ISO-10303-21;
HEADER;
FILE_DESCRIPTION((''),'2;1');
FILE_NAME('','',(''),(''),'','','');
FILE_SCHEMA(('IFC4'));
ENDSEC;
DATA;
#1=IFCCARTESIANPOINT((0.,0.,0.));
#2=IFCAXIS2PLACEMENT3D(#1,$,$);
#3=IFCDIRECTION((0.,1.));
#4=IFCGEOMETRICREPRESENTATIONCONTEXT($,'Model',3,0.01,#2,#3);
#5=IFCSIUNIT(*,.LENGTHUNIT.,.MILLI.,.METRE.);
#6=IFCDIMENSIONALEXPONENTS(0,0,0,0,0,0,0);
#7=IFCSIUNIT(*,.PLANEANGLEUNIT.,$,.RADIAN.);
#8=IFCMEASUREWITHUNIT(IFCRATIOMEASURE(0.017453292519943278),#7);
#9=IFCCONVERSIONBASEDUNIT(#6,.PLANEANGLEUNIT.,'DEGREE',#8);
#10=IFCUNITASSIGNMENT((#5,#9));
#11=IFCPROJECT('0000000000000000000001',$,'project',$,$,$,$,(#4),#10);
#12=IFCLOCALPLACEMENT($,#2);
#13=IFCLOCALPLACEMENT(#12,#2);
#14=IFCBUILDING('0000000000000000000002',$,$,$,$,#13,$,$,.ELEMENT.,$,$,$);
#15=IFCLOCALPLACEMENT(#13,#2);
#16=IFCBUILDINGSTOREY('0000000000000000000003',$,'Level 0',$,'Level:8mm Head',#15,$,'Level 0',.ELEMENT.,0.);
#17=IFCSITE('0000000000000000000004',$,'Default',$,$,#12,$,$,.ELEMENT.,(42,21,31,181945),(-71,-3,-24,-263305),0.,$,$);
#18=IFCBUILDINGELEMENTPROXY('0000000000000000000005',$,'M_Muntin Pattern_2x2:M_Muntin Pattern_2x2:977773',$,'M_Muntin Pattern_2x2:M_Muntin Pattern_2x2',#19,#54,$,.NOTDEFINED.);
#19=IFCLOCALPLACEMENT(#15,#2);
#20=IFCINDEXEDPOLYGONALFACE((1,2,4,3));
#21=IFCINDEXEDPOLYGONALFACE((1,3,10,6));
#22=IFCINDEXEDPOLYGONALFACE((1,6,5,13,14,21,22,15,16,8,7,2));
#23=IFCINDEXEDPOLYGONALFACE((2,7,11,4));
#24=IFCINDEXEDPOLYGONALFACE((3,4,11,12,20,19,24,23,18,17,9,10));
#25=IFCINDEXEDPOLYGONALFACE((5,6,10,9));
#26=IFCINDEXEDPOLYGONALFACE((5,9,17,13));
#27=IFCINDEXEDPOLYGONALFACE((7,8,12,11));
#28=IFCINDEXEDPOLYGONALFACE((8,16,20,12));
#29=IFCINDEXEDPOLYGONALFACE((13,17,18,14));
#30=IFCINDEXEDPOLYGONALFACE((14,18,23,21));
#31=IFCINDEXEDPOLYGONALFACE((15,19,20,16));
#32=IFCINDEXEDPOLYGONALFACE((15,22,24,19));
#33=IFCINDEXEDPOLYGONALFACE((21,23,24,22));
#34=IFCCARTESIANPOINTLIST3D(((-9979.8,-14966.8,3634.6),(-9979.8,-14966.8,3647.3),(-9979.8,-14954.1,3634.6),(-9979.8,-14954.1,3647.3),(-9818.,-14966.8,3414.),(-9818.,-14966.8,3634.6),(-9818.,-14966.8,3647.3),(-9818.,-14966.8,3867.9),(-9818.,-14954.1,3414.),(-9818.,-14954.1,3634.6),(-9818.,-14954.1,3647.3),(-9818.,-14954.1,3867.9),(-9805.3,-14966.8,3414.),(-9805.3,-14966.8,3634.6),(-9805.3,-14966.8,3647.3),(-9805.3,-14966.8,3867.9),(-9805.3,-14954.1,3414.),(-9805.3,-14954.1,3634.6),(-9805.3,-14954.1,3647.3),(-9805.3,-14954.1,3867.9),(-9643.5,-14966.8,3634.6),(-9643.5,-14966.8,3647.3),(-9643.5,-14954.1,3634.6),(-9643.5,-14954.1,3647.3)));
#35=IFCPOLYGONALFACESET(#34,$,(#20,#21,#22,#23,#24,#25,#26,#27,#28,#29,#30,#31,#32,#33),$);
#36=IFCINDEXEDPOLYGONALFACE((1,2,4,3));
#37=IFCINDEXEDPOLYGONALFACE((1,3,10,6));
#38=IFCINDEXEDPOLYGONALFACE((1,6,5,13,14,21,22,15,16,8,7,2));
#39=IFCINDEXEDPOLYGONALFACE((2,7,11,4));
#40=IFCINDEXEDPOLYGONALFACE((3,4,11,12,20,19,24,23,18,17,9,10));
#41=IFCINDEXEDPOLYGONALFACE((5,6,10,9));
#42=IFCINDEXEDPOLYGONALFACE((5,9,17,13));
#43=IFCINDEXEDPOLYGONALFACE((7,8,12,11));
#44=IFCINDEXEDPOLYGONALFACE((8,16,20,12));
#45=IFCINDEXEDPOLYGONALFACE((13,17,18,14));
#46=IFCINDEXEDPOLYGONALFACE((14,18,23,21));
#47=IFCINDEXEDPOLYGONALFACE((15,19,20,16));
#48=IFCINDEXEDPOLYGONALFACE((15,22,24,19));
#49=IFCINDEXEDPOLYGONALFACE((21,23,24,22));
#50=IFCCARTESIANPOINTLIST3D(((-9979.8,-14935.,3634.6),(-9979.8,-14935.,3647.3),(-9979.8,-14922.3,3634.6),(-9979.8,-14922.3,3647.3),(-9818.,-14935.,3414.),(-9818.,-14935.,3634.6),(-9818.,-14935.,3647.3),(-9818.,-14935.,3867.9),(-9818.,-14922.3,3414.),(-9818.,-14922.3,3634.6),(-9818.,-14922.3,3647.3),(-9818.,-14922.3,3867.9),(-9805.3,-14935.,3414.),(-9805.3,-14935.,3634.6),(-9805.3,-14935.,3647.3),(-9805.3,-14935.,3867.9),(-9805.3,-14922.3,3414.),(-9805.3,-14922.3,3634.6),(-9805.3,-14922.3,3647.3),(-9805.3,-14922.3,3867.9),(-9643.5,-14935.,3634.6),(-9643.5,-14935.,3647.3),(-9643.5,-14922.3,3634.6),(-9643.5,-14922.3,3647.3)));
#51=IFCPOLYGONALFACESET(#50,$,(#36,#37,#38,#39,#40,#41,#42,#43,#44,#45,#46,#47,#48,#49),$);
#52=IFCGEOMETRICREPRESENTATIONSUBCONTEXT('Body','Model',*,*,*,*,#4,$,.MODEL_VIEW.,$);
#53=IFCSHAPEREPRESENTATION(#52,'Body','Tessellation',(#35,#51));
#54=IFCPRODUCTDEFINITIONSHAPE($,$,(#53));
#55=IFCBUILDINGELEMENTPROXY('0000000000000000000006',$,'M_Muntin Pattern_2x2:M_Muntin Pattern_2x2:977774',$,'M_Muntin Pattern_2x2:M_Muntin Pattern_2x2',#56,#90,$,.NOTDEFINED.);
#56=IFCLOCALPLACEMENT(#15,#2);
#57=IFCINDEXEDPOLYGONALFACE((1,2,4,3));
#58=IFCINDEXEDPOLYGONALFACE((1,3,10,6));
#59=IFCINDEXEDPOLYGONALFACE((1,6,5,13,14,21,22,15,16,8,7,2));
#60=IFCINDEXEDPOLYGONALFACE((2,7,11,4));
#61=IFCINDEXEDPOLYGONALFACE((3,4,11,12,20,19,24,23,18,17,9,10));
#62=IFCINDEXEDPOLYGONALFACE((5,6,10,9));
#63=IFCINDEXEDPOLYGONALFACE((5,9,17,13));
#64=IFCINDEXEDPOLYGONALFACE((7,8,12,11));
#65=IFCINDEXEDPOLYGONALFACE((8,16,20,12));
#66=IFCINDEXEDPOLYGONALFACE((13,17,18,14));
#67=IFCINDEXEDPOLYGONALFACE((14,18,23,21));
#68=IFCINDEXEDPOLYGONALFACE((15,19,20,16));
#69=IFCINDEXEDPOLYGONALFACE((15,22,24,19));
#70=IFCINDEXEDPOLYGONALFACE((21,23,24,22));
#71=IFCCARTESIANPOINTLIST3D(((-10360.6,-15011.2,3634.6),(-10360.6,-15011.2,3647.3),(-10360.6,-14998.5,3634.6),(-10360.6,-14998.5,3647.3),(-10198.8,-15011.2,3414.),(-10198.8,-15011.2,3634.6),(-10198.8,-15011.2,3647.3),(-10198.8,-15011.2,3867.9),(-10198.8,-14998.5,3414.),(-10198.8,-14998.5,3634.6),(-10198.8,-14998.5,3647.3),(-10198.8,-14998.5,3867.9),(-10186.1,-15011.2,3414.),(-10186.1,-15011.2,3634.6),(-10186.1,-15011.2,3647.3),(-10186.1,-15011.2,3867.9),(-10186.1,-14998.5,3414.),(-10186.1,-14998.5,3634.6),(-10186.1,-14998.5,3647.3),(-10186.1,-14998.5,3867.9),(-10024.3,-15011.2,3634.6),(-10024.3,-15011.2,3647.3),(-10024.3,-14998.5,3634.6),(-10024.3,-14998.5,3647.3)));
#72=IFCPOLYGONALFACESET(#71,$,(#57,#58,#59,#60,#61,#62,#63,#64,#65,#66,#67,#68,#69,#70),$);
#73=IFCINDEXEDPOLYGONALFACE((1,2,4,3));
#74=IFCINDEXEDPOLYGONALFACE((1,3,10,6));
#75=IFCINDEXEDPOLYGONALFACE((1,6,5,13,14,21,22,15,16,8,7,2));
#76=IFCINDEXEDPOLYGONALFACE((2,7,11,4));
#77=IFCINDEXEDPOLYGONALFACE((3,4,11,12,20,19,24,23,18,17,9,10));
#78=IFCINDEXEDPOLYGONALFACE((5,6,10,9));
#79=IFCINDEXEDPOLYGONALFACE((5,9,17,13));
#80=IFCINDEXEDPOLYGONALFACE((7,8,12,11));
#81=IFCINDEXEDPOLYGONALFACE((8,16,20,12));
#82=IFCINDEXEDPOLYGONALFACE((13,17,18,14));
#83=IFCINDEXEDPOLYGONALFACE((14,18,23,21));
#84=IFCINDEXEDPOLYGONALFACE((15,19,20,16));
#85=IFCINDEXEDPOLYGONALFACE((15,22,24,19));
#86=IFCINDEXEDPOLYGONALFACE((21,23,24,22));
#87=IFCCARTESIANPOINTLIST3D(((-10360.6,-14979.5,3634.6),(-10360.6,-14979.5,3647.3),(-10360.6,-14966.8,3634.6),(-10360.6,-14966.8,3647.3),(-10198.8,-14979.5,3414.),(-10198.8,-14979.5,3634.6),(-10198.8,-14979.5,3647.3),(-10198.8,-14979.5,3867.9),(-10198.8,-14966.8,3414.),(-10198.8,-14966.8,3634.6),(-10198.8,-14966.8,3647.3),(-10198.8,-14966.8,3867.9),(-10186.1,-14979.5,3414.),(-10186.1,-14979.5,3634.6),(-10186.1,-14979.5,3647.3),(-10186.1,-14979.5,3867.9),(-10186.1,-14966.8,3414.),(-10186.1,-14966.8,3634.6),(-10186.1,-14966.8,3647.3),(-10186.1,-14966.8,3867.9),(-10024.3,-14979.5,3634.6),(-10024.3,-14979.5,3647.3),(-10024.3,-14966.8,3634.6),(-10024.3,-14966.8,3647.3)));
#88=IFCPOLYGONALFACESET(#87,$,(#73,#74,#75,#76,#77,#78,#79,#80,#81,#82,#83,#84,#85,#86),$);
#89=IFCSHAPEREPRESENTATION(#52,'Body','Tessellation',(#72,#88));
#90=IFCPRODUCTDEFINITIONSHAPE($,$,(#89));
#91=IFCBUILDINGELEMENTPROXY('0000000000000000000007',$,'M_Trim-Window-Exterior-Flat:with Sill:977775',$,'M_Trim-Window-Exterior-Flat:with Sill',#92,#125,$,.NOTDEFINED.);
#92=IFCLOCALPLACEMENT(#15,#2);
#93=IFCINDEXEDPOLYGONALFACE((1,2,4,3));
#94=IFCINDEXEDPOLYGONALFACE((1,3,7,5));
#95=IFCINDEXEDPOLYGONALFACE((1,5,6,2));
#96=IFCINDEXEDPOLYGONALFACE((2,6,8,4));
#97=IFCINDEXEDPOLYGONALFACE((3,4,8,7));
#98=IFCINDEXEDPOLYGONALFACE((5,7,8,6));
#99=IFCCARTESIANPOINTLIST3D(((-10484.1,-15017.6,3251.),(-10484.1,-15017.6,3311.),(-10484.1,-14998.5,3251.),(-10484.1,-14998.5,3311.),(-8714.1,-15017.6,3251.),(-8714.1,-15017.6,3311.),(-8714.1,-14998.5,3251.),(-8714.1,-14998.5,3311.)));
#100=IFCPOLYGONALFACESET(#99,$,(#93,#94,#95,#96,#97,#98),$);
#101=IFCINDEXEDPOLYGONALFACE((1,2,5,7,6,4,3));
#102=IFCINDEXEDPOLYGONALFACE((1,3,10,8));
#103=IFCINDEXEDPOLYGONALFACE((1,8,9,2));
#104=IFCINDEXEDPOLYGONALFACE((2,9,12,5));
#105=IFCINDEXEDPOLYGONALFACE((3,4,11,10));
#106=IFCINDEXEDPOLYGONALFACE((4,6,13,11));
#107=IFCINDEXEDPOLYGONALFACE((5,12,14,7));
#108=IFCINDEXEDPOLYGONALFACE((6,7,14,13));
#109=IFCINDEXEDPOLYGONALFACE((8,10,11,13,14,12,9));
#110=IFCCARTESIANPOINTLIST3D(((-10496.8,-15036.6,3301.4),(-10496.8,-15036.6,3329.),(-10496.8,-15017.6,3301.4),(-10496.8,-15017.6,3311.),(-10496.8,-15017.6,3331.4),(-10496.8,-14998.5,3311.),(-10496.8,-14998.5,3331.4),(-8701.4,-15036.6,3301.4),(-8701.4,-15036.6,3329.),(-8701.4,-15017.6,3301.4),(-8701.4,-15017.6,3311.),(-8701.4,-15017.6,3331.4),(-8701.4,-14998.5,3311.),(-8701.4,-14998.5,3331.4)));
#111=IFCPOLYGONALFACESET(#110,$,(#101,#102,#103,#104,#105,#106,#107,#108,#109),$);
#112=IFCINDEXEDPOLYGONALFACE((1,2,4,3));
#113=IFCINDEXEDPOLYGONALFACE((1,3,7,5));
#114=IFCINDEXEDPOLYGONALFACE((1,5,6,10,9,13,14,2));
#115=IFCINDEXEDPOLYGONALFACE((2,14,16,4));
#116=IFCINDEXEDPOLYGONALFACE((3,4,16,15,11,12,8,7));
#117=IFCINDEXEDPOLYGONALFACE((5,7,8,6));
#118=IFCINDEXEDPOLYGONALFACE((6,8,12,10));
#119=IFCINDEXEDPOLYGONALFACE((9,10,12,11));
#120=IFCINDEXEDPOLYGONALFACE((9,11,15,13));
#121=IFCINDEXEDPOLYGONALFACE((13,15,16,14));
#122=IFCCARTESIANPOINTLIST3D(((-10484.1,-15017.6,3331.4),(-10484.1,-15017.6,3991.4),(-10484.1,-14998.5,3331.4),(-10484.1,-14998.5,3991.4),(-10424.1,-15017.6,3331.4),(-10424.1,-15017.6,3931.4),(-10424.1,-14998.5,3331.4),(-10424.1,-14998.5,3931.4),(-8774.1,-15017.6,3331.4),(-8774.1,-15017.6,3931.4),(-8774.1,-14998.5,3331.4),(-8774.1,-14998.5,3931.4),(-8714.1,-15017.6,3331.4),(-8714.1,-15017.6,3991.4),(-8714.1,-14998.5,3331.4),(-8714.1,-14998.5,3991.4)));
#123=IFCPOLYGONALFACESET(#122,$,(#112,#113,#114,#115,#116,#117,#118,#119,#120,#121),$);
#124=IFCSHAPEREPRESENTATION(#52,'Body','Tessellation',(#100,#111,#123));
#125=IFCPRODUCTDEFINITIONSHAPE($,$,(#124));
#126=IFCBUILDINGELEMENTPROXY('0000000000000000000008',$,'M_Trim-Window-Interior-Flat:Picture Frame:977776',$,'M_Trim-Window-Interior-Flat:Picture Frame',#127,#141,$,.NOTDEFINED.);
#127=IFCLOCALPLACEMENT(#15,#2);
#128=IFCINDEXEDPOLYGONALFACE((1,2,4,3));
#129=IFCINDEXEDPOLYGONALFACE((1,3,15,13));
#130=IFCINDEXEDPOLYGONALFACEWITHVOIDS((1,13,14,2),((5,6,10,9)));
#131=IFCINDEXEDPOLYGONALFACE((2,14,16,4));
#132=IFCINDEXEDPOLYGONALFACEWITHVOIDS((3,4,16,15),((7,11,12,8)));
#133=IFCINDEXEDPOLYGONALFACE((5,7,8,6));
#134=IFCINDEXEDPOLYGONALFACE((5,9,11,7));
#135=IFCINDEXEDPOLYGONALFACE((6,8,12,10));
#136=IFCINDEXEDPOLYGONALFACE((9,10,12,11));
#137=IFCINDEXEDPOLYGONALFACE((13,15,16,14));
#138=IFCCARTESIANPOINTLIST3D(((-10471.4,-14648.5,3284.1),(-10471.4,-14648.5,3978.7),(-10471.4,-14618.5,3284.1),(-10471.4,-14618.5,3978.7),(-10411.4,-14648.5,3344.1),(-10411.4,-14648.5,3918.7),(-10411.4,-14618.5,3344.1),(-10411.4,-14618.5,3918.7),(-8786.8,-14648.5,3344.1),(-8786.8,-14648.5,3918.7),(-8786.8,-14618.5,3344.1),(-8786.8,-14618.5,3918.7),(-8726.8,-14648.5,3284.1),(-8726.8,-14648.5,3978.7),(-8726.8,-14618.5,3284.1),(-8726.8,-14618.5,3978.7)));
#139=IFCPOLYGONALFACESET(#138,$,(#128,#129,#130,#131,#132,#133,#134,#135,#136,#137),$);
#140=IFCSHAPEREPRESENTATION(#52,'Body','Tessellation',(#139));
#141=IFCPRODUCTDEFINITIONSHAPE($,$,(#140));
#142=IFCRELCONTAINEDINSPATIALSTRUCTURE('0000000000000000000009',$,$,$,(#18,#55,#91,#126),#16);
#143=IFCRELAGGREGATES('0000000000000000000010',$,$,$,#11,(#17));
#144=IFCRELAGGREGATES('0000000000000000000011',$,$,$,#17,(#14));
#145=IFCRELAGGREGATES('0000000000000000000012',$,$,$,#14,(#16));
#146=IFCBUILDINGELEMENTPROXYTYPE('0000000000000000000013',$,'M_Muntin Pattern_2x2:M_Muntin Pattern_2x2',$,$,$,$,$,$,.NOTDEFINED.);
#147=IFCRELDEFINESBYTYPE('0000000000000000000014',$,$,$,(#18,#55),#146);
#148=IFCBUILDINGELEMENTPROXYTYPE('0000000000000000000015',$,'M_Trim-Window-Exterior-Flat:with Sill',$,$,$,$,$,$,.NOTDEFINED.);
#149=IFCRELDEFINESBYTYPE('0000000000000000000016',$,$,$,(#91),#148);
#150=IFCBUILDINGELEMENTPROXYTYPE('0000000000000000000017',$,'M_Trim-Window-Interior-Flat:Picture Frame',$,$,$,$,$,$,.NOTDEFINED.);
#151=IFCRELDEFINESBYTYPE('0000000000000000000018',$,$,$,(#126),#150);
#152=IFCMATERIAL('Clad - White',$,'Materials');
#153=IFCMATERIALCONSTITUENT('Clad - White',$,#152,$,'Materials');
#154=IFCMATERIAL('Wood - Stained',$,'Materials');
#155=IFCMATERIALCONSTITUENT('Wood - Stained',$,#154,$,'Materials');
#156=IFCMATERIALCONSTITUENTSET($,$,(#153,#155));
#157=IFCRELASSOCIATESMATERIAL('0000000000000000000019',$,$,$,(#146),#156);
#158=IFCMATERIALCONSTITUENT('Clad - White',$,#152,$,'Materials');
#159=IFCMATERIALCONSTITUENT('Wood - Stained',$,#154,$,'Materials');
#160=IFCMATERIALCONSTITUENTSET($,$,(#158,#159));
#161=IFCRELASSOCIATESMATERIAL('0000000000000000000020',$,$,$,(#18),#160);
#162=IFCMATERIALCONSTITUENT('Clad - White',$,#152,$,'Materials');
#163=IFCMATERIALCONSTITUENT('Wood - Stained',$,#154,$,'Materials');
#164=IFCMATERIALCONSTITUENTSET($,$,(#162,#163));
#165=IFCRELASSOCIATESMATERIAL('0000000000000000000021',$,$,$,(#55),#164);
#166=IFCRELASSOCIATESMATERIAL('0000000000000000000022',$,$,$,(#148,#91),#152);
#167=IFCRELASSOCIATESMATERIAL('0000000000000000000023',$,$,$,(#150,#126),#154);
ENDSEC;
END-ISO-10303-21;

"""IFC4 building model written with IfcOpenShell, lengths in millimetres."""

from ifc_helpers import new_model, entity, si_unit, converted_unit, direction, frame, frame_2d, origin, place, context, subcontext, project, spatial, polyline, rectangle, outline, extrude, source, transform, mapped, material, constituent, constituent_set, type_object, type_shapes, element, save


model = new_model("IFC4")

# Units and contexts
model_context = context("Model", 3, precision=0.01, world=origin(), true_north=direction((0.0, 1.0)))
body_context = subcontext(model_context, "Body", "Model", "MODEL_VIEW")
ifc_project = project(units=[si_unit("LENGTHUNIT", "METRE", prefix="MILLI"), converted_unit("PLANEANGLEUNIT", "DEGREE", entity("IfcRatioMeasure", 0.017453292519943278), si_unit("PLANEANGLEUNIT", "RADIAN"), dimensions=[0, 0, 0, 0, 0, 0, 0])], contexts=[model_context])

# Site, building, storey
site_placement = place(None, origin())
site = spatial("IfcSite", under=ifc_project, at=site_placement, Name="Default", CompositionType="ELEMENT", RefLatitude=(42, 21, 31, 181945), RefLongitude=(-71, -3, -24, -263305), RefElevation=0.0)
building_placement = place(site_placement, origin())
building = spatial("IfcBuilding", under=site, at=building_placement, CompositionType="ELEMENT")
storey_placement = place(building_placement, origin())
storey = spatial("IfcBuildingStorey", under=building, at=storey_placement, Name="Level 0", ObjectType="Level:8mm Head", LongName="Level 0", CompositionType="ELEMENT", Elevation=0.0)

# Building element proxies
ifc_material_1 = material(Name="Clad - White", Category="Materials")
ifc_material_2 = material(Name="Wood - Stained", Category="Materials")
ifc_constituent_1 = constituent(ifc_material_1, Name="Clad - White", Category="Materials")
ifc_constituent_2 = constituent(ifc_material_2, Name="Wood - Stained", Category="Materials")
ifc_constituent_set_1 = constituent_set(constituents=[ifc_constituent_1, ifc_constituent_2])
building_element_proxy_type_1 = type_object("IfcBuildingElementProxyType", Name="M_Muntin Pattern_2x2:M_Muntin Pattern_2x2", PredefinedType="NOTDEFINED", material=ifc_constituent_set_1)
shared_shape_1 = source(origin(), body_context, "Body", "SweptSolid", [
    extrude(outline(polyline([(6.4, -6.4), (227.0, -6.4), (227.0, 6.3), (6.4, 6.3), (6.4, 168.2), (-6.3, 168.2), (-6.3, 6.3), (-227.0, 6.3), (-227.0, -6.4), (-6.3, -6.4), (-6.3, -168.1), (6.4, -168.1), (6.4, -6.4)])), frame((0.0, 9.5, 227.0), z_axis=(0.0, 1.0, 0.0), x_axis=(0.0, 0.0, 1.0)), (0.0, 0.0, 1.0), 12.7),
    extrude(outline(polyline([(6.4, -6.4), (227.0, -6.4), (227.0, 6.3), (6.4, 6.3), (6.4, 168.2), (-6.3, 168.2), (-6.3, 6.3), (-227.0, 6.3), (-227.0, -6.4), (-6.3, -6.4), (-6.3, -168.1), (6.4, -168.1), (6.4, -6.4)])), frame((0.0, -22.2, 227.0), z_axis=(0.0, 1.0, 0.0), x_axis=(0.0, 0.0, 1.0)), (0.0, 0.0, 1.0), 12.7),
])
type_shapes(building_element_proxy_type_1, [shared_shape_1])
ifc_constituent_3 = constituent(ifc_material_1, Name="Clad - White", Category="Materials")
ifc_constituent_4 = constituent(ifc_material_2, Name="Wood - Stained", Category="Materials")
ifc_constituent_set_2 = constituent_set(constituents=[ifc_constituent_3, ifc_constituent_4])
proxy_1_placement = place(storey_placement, frame((-9811.7, -14944.6, 3414.0), z_axis=(0.0, 0.0, 1.0), x_axis=(-1.0, 0.0, 0.0)))
element("IfcBuildingElementProxy", 1, at=proxy_1_placement, inside=storey, type_object=building_element_proxy_type_1, material=ifc_constituent_set_2, Name="M_Muntin Pattern_2x2:M_Muntin Pattern_2x2:977773", ObjectType="M_Muntin Pattern_2x2:M_Muntin Pattern_2x2", PredefinedType="NOTDEFINED", context=body_context, shape_type="MappedRepresentation", body=[
    mapped(shared_shape_1, transform((0.0, 0.0, 0.0), scale=1.0)),
])
ifc_constituent_5 = constituent(ifc_material_1, Name="Clad - White", Category="Materials")
ifc_constituent_6 = constituent(ifc_material_2, Name="Wood - Stained", Category="Materials")
ifc_constituent_set_3 = constituent_set(constituents=[ifc_constituent_5, ifc_constituent_6])
proxy_2_placement = place(storey_placement, frame((-10192.4, -14989.0, 3414.0), z_axis=(0.0, 0.0, 1.0), x_axis=(-1.0, 0.0, 0.0)))
element("IfcBuildingElementProxy", 2, at=proxy_2_placement, inside=storey, type_object=building_element_proxy_type_1, material=ifc_constituent_set_3, Name="M_Muntin Pattern_2x2:M_Muntin Pattern_2x2:977774", ObjectType="M_Muntin Pattern_2x2:M_Muntin Pattern_2x2", PredefinedType="NOTDEFINED", context=body_context, shape_type="MappedRepresentation", body=[
    mapped(shared_shape_1, transform((0.0, 0.0, 0.0), scale=1.0)),
])
building_element_proxy_type_2 = type_object("IfcBuildingElementProxyType", Name="M_Trim-Window-Exterior-Flat:with Sill", PredefinedType="NOTDEFINED", material=ifc_material_1)
shared_shape_2 = source(origin(), body_context, "Body", "SweptSolid", [
    extrude(rectangle(XDim=1770.0, YDim=60.0, at=frame_2d((0.0, 0.0), x_axis=(1.0, 0.0))), frame((0.0, -650.4, 0.0), z_axis=(0.0, 0.0, 1.0), x_axis=(-1.0, 0.0, 0.0)), (0.0, 0.0, 1.0), 19.0),
    extrude(outline(polyline([(-19.0, -15.2), (0.0, -15.2), (0.0, -5.7), (19.0, -5.7), (19.0, 14.8), (0.0, 14.8), (-19.0, 12.3), (-19.0, -15.2)])), frame((-897.7, -614.8, 19.0), z_axis=(1.0, 0.0, 0.0), x_axis=(0.0, 0.0, -1.0)), (0.0, 0.0, 1.0), 1795.4),
    extrude(outline(polyline([(-345.0, -885.0), (315.0, -885.0), (315.0, -825.0), (-285.0, -825.0), (-285.0, 825.0), (315.0, 825.0), (315.0, 885.0), (-345.0, 885.0), (-345.0, -885.0)])), frame((0.0, -285.0, 0.0), z_axis=(0.0, 0.0, 1.0), x_axis=(0.0, -1.0, 0.0)), (0.0, 0.0, 1.0), 19.0),
])
type_shapes(building_element_proxy_type_2, [shared_shape_2])
proxy_3_placement = place(storey_placement, frame((-9599.1, -14998.5, 3931.4), z_axis=(0.0, -1.0, 0.0), x_axis=(1.0, 0.0, 0.0)))
element("IfcBuildingElementProxy", 3, at=proxy_3_placement, inside=storey, type_object=building_element_proxy_type_2, material=ifc_material_1, Name="M_Trim-Window-Exterior-Flat:with Sill:977775", ObjectType="M_Trim-Window-Exterior-Flat:with Sill", PredefinedType="NOTDEFINED", context=body_context, shape_type="MappedRepresentation", body=[
    mapped(shared_shape_2, transform((0.0, 0.0, 0.0), scale=1.0)),
])
building_element_proxy_type_3 = type_object("IfcBuildingElementProxyType", Name="M_Trim-Window-Interior-Flat:Picture Frame", PredefinedType="NOTDEFINED", material=ifc_material_2)
shared_shape_3 = source(origin(), body_context, "Body", "SweptSolid", [
    extrude(outline(polyline([(-872.3, -347.3), (872.3, -347.3), (872.3, 347.3), (-872.3, 347.3), (-872.3, -347.3)]), holes=[polyline([(-812.3, -287.3), (-812.3, 287.3), (812.3, 287.3), (812.3, -287.3), (-812.3, -287.3)])]), frame((0.0, -300.0, 0.0), z_axis=(0.0, 0.0, 1.0), x_axis=(-1.0, 0.0, 0.0)), (0.0, 0.0, 1.0), 30.0),
])
type_shapes(building_element_proxy_type_3, [shared_shape_3])
proxy_4_placement = place(storey_placement, frame((-9599.1, -14648.5, 3931.4), z_axis=(0.0, 1.0, 0.0), x_axis=(-1.0, 0.0, 0.0)))
element("IfcBuildingElementProxy", 4, at=proxy_4_placement, inside=storey, type_object=building_element_proxy_type_3, material=ifc_material_2, Name="M_Trim-Window-Interior-Flat:Picture Frame:977776", ObjectType="M_Trim-Window-Interior-Flat:Picture Frame", PredefinedType="NOTDEFINED", context=body_context, shape_type="MappedRepresentation", body=[
    mapped(shared_shape_3, transform((0.0, 0.0, 0.0), scale=1.0)),
])

save(model, "model.ifc")
